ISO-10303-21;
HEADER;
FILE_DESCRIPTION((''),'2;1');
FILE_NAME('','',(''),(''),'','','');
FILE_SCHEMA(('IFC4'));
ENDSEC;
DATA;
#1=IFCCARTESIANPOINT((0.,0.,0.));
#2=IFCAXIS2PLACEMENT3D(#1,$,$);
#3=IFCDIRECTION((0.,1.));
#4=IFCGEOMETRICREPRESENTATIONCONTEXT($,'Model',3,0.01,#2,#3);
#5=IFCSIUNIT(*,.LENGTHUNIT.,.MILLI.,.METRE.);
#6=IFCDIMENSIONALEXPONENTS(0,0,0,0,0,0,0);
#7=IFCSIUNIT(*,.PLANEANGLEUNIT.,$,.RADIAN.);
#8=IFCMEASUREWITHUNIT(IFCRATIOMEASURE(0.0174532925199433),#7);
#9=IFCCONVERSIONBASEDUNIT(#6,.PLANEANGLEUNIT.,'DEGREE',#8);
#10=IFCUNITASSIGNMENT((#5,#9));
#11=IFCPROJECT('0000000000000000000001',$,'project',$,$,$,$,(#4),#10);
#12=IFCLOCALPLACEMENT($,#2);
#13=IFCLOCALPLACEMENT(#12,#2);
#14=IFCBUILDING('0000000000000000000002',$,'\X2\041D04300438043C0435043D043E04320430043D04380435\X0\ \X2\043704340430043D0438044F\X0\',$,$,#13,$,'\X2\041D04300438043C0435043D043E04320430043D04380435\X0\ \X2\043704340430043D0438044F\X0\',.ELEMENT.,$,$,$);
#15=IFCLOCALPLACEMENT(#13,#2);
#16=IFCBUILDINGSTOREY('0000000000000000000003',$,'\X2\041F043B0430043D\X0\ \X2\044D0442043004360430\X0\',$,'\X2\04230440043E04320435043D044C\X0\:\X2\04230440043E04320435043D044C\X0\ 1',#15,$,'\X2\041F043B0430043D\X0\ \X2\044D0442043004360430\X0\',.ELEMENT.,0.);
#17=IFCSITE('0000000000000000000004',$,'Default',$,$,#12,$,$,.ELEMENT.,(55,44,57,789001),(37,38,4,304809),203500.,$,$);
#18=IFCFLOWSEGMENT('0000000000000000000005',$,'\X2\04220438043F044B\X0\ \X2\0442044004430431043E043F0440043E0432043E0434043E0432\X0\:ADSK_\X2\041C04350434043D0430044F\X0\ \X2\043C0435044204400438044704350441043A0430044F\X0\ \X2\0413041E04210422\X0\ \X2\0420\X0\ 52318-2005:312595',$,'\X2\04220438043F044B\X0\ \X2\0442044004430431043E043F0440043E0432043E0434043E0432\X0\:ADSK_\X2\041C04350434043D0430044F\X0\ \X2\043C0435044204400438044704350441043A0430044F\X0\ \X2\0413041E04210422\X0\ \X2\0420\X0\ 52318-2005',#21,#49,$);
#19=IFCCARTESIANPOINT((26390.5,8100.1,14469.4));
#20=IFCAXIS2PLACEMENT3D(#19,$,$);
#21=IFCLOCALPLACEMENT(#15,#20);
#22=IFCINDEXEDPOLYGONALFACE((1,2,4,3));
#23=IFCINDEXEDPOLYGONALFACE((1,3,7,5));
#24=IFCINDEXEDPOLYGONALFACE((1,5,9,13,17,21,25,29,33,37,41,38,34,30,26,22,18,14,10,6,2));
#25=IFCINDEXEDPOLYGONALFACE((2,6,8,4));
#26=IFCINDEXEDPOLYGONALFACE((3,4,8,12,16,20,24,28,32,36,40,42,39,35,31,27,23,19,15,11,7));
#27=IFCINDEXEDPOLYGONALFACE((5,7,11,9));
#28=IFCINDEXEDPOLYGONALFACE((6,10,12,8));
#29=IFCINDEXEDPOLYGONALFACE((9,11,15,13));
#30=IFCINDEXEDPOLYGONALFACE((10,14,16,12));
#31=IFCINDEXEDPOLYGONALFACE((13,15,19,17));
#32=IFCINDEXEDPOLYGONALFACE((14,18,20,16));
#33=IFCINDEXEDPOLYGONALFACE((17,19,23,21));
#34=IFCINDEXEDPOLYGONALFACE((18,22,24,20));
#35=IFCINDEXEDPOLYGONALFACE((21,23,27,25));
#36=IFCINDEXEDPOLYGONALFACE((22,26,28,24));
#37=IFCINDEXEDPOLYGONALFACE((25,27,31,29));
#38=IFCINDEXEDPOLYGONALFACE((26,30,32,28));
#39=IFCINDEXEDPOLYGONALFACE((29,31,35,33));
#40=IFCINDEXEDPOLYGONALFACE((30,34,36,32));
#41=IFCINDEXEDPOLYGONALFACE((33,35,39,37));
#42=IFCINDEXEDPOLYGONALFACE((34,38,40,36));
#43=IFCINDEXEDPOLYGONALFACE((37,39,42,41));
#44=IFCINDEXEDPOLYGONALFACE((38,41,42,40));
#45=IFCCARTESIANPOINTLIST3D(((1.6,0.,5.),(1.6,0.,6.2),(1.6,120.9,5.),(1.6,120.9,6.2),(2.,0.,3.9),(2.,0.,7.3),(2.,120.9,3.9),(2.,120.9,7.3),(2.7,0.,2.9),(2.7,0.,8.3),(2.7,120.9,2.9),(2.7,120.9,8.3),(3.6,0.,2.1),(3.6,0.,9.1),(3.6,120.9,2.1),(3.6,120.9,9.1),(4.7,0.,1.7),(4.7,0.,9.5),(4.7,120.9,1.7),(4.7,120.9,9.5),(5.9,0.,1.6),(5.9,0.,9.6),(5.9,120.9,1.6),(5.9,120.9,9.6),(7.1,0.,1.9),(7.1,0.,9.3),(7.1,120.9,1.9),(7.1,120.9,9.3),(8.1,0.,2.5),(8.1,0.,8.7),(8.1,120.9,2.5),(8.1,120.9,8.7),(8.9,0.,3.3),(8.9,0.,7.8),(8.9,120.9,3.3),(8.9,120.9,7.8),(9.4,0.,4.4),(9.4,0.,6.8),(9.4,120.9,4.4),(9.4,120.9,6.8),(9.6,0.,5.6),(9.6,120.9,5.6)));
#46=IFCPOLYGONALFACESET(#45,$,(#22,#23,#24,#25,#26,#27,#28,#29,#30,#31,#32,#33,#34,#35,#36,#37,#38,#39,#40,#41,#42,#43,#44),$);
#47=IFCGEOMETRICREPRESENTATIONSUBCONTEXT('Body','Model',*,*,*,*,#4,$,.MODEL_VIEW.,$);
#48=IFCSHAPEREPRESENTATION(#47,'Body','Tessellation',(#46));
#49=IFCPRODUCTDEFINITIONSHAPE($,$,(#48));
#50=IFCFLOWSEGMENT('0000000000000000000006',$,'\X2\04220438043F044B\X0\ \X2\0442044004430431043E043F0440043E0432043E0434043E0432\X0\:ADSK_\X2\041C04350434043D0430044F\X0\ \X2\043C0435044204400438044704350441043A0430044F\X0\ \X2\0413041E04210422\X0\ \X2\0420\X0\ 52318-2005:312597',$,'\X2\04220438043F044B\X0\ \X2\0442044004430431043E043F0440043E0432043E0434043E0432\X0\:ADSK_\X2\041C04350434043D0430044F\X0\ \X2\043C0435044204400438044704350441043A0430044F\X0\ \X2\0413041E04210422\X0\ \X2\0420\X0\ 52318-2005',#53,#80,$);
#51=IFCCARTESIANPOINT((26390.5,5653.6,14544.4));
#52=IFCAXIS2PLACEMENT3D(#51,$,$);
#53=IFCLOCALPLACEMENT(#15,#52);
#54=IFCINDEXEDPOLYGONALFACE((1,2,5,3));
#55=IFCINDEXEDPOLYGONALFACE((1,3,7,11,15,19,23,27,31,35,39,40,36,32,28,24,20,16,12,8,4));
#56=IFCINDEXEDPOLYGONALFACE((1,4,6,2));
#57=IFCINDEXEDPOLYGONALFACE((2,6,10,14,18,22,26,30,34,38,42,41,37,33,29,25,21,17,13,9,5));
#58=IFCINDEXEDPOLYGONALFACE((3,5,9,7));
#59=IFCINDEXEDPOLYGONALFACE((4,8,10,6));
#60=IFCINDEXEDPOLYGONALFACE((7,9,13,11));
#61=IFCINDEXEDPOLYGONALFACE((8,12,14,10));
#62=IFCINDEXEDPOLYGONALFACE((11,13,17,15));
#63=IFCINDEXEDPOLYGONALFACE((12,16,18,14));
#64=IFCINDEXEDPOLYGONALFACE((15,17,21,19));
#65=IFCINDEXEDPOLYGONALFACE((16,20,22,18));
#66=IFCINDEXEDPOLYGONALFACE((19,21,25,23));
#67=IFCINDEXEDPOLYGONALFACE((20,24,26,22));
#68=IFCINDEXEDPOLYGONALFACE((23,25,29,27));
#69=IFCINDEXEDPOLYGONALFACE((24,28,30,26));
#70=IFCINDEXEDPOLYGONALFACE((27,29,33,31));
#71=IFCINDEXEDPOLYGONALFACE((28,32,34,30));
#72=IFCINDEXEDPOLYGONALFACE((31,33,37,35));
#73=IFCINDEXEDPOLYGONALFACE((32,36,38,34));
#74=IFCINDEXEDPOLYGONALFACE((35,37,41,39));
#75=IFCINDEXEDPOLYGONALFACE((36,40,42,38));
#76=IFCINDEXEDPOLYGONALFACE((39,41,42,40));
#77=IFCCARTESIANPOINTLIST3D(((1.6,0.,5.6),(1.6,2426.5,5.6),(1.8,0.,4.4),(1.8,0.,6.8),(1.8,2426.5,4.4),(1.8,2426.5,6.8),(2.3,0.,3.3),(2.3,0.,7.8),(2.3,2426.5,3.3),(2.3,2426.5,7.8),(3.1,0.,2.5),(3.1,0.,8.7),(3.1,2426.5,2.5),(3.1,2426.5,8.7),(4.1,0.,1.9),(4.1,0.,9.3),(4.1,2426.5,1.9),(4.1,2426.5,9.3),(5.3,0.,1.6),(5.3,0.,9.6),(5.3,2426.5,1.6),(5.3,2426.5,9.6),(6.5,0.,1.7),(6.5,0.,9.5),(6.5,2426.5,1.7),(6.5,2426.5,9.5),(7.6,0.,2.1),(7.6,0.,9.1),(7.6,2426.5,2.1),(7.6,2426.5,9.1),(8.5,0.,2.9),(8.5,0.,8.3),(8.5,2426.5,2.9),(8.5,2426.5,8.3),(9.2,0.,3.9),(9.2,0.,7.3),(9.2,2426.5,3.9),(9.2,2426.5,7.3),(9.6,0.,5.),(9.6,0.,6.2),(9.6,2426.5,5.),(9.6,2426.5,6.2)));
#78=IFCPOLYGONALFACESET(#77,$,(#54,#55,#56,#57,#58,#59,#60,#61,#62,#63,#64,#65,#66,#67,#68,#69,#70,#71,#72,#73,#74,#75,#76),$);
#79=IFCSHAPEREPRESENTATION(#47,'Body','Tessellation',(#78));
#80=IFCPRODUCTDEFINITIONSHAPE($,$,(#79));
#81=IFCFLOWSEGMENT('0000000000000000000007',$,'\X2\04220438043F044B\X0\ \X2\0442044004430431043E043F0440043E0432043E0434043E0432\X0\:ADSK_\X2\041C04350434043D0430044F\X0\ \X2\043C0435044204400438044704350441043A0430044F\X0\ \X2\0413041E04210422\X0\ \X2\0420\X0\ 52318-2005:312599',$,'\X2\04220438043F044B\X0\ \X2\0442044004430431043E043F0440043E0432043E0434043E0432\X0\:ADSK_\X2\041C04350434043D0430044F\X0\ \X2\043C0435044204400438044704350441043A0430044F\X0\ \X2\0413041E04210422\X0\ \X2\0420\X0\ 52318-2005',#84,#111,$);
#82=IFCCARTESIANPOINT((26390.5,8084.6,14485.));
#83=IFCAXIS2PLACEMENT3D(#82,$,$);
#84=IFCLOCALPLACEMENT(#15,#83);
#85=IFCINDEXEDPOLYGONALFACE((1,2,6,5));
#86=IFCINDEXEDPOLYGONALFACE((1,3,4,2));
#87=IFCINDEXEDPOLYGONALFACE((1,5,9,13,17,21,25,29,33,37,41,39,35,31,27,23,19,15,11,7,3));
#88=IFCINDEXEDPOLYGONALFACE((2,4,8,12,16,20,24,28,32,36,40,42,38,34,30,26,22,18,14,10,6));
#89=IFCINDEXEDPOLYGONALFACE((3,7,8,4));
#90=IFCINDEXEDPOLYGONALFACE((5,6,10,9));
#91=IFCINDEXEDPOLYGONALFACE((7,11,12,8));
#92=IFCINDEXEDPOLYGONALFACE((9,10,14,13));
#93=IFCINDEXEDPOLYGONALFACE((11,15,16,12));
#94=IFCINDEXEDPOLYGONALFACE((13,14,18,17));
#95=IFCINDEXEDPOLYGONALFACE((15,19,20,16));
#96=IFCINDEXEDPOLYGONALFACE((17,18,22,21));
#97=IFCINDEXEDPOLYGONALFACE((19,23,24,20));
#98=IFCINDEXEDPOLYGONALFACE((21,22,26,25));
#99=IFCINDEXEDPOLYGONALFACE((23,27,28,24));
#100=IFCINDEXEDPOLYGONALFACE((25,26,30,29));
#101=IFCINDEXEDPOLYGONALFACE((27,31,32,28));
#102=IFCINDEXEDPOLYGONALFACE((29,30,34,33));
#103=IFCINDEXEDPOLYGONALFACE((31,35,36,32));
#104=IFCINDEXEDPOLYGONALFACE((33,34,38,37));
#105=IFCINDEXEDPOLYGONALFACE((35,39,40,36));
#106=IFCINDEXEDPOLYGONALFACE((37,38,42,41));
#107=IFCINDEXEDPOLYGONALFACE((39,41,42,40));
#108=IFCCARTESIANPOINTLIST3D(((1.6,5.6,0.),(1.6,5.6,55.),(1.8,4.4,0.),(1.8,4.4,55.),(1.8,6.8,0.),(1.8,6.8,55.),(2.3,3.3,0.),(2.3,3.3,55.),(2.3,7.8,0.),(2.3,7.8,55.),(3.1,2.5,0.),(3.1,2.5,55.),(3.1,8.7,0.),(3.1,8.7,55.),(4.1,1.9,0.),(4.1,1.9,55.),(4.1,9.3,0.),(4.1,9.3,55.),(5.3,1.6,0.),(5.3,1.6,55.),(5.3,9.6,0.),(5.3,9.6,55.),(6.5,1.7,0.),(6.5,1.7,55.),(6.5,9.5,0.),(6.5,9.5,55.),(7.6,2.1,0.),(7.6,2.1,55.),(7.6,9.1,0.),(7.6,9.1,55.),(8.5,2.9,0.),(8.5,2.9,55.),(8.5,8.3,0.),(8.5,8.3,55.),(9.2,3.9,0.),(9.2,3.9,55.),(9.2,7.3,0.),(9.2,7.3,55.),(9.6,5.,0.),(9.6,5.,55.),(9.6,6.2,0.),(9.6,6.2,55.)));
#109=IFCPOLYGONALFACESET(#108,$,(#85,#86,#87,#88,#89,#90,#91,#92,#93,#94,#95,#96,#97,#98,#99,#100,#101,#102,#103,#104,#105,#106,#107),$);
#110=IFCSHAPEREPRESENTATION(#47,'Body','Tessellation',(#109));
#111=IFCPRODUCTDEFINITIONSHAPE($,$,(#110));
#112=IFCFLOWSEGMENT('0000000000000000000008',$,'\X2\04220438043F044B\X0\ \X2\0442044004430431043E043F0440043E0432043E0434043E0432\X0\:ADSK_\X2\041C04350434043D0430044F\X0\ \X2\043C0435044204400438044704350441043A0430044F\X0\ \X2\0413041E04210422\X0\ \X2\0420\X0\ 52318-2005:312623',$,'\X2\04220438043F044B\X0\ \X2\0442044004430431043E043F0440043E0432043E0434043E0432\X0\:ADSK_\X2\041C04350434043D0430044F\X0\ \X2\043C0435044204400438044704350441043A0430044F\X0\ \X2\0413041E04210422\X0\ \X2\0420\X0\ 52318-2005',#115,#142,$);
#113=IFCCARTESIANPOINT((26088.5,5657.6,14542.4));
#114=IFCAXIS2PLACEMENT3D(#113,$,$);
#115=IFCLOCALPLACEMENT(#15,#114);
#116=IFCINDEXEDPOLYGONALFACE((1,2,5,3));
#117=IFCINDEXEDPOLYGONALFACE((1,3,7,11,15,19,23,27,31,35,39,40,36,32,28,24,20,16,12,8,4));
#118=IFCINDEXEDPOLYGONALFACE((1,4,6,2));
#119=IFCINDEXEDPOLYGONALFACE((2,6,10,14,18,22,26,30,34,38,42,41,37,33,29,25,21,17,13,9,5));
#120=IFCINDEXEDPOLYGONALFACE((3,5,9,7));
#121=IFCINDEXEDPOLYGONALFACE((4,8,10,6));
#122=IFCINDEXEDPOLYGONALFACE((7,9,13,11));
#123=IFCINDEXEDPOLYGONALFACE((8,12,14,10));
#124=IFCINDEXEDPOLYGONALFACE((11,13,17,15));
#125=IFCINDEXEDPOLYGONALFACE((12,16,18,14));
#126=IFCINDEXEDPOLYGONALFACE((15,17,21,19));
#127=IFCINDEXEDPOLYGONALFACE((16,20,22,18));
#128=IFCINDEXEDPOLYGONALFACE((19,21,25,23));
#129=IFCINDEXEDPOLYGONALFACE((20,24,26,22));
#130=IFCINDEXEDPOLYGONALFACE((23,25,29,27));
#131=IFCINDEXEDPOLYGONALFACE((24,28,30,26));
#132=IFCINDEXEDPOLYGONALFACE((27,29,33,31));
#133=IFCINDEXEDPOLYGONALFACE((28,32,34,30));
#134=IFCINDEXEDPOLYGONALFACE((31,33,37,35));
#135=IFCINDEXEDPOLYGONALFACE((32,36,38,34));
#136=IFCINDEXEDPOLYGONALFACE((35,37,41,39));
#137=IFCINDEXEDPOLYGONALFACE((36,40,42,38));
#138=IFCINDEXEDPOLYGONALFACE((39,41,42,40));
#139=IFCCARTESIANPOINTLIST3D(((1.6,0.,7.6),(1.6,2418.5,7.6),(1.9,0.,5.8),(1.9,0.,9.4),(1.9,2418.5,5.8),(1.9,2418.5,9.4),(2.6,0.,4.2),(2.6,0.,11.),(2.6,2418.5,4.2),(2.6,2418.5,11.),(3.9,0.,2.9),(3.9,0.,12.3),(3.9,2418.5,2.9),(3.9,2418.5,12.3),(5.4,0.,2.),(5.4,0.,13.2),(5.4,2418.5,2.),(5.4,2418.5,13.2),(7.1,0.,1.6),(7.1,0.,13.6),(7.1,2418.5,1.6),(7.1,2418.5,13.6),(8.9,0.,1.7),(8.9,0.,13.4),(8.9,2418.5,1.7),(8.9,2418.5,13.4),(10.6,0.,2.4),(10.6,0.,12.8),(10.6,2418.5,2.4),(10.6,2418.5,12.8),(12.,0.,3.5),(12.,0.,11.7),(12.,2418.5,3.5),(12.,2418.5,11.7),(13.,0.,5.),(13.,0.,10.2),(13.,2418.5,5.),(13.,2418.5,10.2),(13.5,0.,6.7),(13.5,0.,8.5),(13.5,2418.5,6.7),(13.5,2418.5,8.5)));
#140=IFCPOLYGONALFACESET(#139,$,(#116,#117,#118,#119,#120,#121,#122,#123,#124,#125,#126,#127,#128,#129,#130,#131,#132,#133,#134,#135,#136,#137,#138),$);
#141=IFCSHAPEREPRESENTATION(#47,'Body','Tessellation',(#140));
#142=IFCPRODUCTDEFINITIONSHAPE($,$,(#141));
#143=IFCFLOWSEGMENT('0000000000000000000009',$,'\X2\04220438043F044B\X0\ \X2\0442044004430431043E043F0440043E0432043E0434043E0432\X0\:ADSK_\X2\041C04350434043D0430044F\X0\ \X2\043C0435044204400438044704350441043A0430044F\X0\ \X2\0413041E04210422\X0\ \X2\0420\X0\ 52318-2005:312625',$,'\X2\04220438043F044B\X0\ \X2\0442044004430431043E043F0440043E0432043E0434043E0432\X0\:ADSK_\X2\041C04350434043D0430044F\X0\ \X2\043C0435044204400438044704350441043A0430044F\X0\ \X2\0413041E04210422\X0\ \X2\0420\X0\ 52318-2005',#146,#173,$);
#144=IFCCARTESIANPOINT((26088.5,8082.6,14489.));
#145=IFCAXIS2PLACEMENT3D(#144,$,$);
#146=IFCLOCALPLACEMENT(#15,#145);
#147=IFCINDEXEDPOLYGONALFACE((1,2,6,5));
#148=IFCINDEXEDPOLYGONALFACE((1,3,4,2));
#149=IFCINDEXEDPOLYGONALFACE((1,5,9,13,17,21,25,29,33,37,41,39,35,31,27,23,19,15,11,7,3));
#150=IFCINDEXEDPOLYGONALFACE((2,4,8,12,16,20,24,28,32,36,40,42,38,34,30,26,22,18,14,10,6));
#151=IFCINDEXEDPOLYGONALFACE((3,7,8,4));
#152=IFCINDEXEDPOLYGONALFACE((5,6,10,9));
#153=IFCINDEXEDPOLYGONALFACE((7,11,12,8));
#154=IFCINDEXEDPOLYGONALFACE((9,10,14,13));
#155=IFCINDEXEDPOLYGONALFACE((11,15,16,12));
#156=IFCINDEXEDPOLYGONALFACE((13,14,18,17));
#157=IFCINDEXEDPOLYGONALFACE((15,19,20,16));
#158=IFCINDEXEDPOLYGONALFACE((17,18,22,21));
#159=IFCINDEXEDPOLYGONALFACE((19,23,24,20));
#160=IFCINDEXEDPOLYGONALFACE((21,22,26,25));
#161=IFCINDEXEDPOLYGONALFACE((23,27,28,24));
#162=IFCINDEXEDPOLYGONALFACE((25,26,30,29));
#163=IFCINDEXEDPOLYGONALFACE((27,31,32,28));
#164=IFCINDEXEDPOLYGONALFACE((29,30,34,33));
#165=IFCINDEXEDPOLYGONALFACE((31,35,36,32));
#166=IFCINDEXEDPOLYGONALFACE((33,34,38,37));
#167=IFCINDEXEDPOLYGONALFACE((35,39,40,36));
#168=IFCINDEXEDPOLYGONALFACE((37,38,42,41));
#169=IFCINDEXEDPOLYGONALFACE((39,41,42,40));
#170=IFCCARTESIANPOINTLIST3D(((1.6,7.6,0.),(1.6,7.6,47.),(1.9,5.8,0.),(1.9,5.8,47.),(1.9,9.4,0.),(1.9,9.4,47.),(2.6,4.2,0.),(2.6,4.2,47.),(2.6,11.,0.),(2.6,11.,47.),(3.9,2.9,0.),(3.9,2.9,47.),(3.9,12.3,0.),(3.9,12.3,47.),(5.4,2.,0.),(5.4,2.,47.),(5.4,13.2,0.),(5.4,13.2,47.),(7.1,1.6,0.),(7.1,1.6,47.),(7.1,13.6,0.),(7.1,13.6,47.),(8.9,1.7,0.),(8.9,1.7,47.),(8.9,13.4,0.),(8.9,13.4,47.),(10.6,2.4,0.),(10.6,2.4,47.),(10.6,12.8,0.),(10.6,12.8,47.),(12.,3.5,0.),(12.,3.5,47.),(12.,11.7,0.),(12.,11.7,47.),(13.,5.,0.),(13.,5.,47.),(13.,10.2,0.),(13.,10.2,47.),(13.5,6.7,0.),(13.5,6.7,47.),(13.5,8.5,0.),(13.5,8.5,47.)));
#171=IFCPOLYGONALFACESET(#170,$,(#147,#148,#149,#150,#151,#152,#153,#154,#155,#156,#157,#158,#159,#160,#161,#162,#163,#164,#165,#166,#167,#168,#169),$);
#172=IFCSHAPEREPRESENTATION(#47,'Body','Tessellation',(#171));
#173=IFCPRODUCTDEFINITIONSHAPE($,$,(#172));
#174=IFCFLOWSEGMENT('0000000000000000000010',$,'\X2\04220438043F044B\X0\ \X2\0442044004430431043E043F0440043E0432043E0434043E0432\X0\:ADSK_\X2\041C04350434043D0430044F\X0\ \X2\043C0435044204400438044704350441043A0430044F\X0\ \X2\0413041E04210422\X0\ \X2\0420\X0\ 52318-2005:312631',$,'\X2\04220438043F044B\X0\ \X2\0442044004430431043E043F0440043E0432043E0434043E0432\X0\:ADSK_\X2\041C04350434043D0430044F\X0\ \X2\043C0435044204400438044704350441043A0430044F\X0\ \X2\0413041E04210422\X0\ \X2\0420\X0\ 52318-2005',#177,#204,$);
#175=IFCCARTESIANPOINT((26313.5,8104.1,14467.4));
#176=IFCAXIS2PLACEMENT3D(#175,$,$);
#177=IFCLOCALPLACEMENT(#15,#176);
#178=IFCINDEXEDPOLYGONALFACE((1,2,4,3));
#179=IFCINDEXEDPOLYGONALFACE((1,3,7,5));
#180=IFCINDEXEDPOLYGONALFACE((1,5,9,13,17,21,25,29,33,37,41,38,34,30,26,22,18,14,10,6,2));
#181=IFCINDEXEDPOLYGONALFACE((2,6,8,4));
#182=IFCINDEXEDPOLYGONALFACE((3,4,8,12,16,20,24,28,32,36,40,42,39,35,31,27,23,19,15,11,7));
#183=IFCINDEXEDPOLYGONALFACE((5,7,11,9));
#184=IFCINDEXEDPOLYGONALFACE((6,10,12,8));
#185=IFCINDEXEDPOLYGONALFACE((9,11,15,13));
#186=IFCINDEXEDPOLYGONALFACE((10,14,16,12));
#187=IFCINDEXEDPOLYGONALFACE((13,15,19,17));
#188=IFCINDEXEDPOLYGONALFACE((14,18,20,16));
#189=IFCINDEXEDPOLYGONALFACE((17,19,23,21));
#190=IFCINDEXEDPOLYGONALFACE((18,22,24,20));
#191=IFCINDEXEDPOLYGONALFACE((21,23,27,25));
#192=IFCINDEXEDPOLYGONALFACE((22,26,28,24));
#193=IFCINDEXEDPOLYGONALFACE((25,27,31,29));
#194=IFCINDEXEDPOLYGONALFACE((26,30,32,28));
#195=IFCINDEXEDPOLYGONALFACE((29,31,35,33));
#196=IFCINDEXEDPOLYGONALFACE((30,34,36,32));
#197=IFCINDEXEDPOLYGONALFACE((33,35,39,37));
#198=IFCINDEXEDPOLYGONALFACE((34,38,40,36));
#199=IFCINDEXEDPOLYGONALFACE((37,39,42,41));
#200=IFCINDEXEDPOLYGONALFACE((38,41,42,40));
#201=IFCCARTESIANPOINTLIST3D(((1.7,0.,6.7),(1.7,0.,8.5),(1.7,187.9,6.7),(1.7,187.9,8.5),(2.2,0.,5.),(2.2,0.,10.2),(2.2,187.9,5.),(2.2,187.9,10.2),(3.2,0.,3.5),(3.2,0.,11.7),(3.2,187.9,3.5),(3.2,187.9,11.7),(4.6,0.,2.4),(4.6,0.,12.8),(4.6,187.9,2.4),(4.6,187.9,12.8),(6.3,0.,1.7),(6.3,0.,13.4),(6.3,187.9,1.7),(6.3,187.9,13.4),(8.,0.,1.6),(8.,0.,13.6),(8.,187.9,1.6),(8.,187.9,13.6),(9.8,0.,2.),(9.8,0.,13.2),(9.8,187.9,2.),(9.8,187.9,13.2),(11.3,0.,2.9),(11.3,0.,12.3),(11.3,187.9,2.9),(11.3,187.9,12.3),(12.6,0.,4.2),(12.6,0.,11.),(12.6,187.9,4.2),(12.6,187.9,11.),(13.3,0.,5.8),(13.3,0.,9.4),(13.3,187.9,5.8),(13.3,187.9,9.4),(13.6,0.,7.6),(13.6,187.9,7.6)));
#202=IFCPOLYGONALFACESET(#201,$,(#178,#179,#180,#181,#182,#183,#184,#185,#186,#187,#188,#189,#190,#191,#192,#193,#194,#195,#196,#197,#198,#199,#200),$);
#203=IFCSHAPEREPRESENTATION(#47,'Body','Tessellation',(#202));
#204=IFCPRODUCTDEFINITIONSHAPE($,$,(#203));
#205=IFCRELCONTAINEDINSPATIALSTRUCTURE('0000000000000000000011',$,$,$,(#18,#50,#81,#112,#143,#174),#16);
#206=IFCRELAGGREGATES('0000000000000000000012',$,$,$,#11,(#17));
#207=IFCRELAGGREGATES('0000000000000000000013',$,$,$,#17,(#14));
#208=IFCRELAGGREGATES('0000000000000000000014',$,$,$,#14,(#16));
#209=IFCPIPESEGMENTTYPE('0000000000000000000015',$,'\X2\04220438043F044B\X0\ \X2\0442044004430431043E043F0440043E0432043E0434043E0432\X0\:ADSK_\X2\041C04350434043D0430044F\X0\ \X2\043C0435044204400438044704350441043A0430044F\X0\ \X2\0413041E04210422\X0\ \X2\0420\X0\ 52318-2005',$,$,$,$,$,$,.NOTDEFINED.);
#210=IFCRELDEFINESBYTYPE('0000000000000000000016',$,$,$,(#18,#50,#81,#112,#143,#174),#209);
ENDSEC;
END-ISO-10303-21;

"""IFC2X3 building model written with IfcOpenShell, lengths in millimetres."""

from ifc_helpers import new_model, entity, si_unit, converted_unit, direction, frame, frame_2d, origin, origin_2d_with_axis, place, context, subcontext, project, spatial, circle, extrude, type_object, element, save


model = new_model("IFC2X3")

# Units and contexts
model_context = context("Model", 3, precision=0.01, world=origin(), true_north=direction((0.0, 1.0)))
body_context = subcontext(model_context, "Body", "Model", "MODEL_VIEW")
ifc_project = project(units=[si_unit("LENGTHUNIT", "METRE", prefix="MILLI"), converted_unit("PLANEANGLEUNIT", "DEGREE", entity("IfcRatioMeasure", 0.0174532925199433), si_unit("PLANEANGLEUNIT", "RADIAN"), dimensions=[0, 0, 0, 0, 0, 0, 0])], contexts=[model_context])

# Site, building, storey
site_placement = place(None, frame((0.0, 0.0, 0.0)))
site = spatial("IfcSite", under=ifc_project, at=site_placement, Name="Default", CompositionType="ELEMENT", RefLatitude=(55, 44, 57, 789001), RefLongitude=(37, 38, 4, 304809), RefElevation=203500.0)
building_placement = place(site_placement, origin())
building = spatial("IfcBuilding", under=site, at=building_placement, Name="Наименование здания", LongName="Наименование здания", CompositionType="ELEMENT")
storey_placement = place(building_placement, origin())
storey = spatial("IfcBuildingStorey", under=building, at=storey_placement, Name="План этажа", ObjectType="Уровень:Уровень 1", LongName="План этажа", CompositionType="ELEMENT", Elevation=0.0)

# Flow segments
pipe_segment_type = type_object("IfcPipeSegmentType", Name="Типы трубопроводов:ADSK_Медная метрическая ГОСТ Р 52318-2005", PredefinedType="NOTDEFINED")
flow_segment_1_placement = place(storey_placement, frame((26390.5, 8100.1, 14469.4)))
element("IfcFlowSegment", 1, at=flow_segment_1_placement, inside=storey, type_object=pipe_segment_type, Name="Типы трубопроводов:ADSK_Медная метрическая ГОСТ Р 52318-2005:312595", ObjectType="Типы трубопроводов:ADSK_Медная метрическая ГОСТ Р 52318-2005", context=body_context, shape_type="SweptSolid", body=[
    extrude(circle(Radius=4.0, at=origin_2d_with_axis()), frame((5.6, 0.0, 5.6), z_axis=(0.0, 1.0, 0.0), x_axis=(1.0, 0.0, 0.0)), (0.0, 0.0, 1.0), 120.9),
])
flow_segment_2_placement = place(storey_placement, frame((26390.5, 5653.6, 14544.4)))
element("IfcFlowSegment", 2, at=flow_segment_2_placement, inside=storey, type_object=pipe_segment_type, Name="Типы трубопроводов:ADSK_Медная метрическая ГОСТ Р 52318-2005:312597", ObjectType="Типы трубопроводов:ADSK_Медная метрическая ГОСТ Р 52318-2005", context=body_context, shape_type="SweptSolid", body=[
    extrude(circle(Radius=4.0, at=origin_2d_with_axis()), frame((5.6, 0.0, 5.6), z_axis=(0.0, 1.0, 0.0), x_axis=(-1.0, 0.0, 0.0)), (0.0, 0.0, 1.0), 2426.5),
])
flow_segment_3_placement = place(storey_placement, frame((26390.5, 8084.6, 14485.0)))
element("IfcFlowSegment", 3, at=flow_segment_3_placement, inside=storey, type_object=pipe_segment_type, Name="Типы трубопроводов:ADSK_Медная метрическая ГОСТ Р 52318-2005:312599", ObjectType="Типы трубопроводов:ADSK_Медная метрическая ГОСТ Р 52318-2005", context=body_context, shape_type="SweptSolid", body=[
    extrude(circle(Radius=4.0, at=origin_2d_with_axis()), frame((5.6, 5.6, 0.0), z_axis=(0.0, 0.0, 1.0), x_axis=(-1.0, 0.0, 0.0)), (0.0, 0.0, 1.0), 55.0),
])
flow_segment_4_placement = place(storey_placement, frame((26088.5, 5657.6, 14542.4)))
element("IfcFlowSegment", 4, at=flow_segment_4_placement, inside=storey, type_object=pipe_segment_type, Name="Типы трубопроводов:ADSK_Медная метрическая ГОСТ Р 52318-2005:312623", ObjectType="Типы трубопроводов:ADSK_Медная метрическая ГОСТ Р 52318-2005", context=body_context, shape_type="SweptSolid", body=[
    extrude(circle(Radius=6.0, at=frame_2d((0.0, 0.0), x_axis=(1.0, 0.0))), frame((7.6, 0.0, 7.6), z_axis=(0.0, 1.0, 0.0), x_axis=(-1.0, 0.0, 0.0)), (0.0, 0.0, 1.0), 2418.5),
])
flow_segment_5_placement = place(storey_placement, frame((26088.5, 8082.6, 14489.0)))
element("IfcFlowSegment", 5, at=flow_segment_5_placement, inside=storey, type_object=pipe_segment_type, Name="Типы трубопроводов:ADSK_Медная метрическая ГОСТ Р 52318-2005:312625", ObjectType="Типы трубопроводов:ADSK_Медная метрическая ГОСТ Р 52318-2005", context=body_context, shape_type="SweptSolid", body=[
    extrude(circle(Radius=6.0, at=origin_2d_with_axis()), frame((7.6, 7.6, 0.0), z_axis=(0.0, 0.0, 1.0), x_axis=(-1.0, 0.0, 0.0)), (0.0, 0.0, 1.0), 47.0),
])
flow_segment_6_placement = place(storey_placement, frame((26313.5, 8104.1, 14467.4)))
element("IfcFlowSegment", 6, at=flow_segment_6_placement, inside=storey, type_object=pipe_segment_type, Name="Типы трубопроводов:ADSK_Медная метрическая ГОСТ Р 52318-2005:312631", ObjectType="Типы трубопроводов:ADSK_Медная метрическая ГОСТ Р 52318-2005", context=body_context, shape_type="SweptSolid", body=[
    extrude(circle(Radius=6.0, at=origin_2d_with_axis()), frame((7.6, 0.0, 7.6), z_axis=(0.0, 1.0, 0.0), x_axis=(1.0, 0.0, 0.0)), (0.0, 0.0, 1.0), 187.9),
])

save(model, "model.ifc")
